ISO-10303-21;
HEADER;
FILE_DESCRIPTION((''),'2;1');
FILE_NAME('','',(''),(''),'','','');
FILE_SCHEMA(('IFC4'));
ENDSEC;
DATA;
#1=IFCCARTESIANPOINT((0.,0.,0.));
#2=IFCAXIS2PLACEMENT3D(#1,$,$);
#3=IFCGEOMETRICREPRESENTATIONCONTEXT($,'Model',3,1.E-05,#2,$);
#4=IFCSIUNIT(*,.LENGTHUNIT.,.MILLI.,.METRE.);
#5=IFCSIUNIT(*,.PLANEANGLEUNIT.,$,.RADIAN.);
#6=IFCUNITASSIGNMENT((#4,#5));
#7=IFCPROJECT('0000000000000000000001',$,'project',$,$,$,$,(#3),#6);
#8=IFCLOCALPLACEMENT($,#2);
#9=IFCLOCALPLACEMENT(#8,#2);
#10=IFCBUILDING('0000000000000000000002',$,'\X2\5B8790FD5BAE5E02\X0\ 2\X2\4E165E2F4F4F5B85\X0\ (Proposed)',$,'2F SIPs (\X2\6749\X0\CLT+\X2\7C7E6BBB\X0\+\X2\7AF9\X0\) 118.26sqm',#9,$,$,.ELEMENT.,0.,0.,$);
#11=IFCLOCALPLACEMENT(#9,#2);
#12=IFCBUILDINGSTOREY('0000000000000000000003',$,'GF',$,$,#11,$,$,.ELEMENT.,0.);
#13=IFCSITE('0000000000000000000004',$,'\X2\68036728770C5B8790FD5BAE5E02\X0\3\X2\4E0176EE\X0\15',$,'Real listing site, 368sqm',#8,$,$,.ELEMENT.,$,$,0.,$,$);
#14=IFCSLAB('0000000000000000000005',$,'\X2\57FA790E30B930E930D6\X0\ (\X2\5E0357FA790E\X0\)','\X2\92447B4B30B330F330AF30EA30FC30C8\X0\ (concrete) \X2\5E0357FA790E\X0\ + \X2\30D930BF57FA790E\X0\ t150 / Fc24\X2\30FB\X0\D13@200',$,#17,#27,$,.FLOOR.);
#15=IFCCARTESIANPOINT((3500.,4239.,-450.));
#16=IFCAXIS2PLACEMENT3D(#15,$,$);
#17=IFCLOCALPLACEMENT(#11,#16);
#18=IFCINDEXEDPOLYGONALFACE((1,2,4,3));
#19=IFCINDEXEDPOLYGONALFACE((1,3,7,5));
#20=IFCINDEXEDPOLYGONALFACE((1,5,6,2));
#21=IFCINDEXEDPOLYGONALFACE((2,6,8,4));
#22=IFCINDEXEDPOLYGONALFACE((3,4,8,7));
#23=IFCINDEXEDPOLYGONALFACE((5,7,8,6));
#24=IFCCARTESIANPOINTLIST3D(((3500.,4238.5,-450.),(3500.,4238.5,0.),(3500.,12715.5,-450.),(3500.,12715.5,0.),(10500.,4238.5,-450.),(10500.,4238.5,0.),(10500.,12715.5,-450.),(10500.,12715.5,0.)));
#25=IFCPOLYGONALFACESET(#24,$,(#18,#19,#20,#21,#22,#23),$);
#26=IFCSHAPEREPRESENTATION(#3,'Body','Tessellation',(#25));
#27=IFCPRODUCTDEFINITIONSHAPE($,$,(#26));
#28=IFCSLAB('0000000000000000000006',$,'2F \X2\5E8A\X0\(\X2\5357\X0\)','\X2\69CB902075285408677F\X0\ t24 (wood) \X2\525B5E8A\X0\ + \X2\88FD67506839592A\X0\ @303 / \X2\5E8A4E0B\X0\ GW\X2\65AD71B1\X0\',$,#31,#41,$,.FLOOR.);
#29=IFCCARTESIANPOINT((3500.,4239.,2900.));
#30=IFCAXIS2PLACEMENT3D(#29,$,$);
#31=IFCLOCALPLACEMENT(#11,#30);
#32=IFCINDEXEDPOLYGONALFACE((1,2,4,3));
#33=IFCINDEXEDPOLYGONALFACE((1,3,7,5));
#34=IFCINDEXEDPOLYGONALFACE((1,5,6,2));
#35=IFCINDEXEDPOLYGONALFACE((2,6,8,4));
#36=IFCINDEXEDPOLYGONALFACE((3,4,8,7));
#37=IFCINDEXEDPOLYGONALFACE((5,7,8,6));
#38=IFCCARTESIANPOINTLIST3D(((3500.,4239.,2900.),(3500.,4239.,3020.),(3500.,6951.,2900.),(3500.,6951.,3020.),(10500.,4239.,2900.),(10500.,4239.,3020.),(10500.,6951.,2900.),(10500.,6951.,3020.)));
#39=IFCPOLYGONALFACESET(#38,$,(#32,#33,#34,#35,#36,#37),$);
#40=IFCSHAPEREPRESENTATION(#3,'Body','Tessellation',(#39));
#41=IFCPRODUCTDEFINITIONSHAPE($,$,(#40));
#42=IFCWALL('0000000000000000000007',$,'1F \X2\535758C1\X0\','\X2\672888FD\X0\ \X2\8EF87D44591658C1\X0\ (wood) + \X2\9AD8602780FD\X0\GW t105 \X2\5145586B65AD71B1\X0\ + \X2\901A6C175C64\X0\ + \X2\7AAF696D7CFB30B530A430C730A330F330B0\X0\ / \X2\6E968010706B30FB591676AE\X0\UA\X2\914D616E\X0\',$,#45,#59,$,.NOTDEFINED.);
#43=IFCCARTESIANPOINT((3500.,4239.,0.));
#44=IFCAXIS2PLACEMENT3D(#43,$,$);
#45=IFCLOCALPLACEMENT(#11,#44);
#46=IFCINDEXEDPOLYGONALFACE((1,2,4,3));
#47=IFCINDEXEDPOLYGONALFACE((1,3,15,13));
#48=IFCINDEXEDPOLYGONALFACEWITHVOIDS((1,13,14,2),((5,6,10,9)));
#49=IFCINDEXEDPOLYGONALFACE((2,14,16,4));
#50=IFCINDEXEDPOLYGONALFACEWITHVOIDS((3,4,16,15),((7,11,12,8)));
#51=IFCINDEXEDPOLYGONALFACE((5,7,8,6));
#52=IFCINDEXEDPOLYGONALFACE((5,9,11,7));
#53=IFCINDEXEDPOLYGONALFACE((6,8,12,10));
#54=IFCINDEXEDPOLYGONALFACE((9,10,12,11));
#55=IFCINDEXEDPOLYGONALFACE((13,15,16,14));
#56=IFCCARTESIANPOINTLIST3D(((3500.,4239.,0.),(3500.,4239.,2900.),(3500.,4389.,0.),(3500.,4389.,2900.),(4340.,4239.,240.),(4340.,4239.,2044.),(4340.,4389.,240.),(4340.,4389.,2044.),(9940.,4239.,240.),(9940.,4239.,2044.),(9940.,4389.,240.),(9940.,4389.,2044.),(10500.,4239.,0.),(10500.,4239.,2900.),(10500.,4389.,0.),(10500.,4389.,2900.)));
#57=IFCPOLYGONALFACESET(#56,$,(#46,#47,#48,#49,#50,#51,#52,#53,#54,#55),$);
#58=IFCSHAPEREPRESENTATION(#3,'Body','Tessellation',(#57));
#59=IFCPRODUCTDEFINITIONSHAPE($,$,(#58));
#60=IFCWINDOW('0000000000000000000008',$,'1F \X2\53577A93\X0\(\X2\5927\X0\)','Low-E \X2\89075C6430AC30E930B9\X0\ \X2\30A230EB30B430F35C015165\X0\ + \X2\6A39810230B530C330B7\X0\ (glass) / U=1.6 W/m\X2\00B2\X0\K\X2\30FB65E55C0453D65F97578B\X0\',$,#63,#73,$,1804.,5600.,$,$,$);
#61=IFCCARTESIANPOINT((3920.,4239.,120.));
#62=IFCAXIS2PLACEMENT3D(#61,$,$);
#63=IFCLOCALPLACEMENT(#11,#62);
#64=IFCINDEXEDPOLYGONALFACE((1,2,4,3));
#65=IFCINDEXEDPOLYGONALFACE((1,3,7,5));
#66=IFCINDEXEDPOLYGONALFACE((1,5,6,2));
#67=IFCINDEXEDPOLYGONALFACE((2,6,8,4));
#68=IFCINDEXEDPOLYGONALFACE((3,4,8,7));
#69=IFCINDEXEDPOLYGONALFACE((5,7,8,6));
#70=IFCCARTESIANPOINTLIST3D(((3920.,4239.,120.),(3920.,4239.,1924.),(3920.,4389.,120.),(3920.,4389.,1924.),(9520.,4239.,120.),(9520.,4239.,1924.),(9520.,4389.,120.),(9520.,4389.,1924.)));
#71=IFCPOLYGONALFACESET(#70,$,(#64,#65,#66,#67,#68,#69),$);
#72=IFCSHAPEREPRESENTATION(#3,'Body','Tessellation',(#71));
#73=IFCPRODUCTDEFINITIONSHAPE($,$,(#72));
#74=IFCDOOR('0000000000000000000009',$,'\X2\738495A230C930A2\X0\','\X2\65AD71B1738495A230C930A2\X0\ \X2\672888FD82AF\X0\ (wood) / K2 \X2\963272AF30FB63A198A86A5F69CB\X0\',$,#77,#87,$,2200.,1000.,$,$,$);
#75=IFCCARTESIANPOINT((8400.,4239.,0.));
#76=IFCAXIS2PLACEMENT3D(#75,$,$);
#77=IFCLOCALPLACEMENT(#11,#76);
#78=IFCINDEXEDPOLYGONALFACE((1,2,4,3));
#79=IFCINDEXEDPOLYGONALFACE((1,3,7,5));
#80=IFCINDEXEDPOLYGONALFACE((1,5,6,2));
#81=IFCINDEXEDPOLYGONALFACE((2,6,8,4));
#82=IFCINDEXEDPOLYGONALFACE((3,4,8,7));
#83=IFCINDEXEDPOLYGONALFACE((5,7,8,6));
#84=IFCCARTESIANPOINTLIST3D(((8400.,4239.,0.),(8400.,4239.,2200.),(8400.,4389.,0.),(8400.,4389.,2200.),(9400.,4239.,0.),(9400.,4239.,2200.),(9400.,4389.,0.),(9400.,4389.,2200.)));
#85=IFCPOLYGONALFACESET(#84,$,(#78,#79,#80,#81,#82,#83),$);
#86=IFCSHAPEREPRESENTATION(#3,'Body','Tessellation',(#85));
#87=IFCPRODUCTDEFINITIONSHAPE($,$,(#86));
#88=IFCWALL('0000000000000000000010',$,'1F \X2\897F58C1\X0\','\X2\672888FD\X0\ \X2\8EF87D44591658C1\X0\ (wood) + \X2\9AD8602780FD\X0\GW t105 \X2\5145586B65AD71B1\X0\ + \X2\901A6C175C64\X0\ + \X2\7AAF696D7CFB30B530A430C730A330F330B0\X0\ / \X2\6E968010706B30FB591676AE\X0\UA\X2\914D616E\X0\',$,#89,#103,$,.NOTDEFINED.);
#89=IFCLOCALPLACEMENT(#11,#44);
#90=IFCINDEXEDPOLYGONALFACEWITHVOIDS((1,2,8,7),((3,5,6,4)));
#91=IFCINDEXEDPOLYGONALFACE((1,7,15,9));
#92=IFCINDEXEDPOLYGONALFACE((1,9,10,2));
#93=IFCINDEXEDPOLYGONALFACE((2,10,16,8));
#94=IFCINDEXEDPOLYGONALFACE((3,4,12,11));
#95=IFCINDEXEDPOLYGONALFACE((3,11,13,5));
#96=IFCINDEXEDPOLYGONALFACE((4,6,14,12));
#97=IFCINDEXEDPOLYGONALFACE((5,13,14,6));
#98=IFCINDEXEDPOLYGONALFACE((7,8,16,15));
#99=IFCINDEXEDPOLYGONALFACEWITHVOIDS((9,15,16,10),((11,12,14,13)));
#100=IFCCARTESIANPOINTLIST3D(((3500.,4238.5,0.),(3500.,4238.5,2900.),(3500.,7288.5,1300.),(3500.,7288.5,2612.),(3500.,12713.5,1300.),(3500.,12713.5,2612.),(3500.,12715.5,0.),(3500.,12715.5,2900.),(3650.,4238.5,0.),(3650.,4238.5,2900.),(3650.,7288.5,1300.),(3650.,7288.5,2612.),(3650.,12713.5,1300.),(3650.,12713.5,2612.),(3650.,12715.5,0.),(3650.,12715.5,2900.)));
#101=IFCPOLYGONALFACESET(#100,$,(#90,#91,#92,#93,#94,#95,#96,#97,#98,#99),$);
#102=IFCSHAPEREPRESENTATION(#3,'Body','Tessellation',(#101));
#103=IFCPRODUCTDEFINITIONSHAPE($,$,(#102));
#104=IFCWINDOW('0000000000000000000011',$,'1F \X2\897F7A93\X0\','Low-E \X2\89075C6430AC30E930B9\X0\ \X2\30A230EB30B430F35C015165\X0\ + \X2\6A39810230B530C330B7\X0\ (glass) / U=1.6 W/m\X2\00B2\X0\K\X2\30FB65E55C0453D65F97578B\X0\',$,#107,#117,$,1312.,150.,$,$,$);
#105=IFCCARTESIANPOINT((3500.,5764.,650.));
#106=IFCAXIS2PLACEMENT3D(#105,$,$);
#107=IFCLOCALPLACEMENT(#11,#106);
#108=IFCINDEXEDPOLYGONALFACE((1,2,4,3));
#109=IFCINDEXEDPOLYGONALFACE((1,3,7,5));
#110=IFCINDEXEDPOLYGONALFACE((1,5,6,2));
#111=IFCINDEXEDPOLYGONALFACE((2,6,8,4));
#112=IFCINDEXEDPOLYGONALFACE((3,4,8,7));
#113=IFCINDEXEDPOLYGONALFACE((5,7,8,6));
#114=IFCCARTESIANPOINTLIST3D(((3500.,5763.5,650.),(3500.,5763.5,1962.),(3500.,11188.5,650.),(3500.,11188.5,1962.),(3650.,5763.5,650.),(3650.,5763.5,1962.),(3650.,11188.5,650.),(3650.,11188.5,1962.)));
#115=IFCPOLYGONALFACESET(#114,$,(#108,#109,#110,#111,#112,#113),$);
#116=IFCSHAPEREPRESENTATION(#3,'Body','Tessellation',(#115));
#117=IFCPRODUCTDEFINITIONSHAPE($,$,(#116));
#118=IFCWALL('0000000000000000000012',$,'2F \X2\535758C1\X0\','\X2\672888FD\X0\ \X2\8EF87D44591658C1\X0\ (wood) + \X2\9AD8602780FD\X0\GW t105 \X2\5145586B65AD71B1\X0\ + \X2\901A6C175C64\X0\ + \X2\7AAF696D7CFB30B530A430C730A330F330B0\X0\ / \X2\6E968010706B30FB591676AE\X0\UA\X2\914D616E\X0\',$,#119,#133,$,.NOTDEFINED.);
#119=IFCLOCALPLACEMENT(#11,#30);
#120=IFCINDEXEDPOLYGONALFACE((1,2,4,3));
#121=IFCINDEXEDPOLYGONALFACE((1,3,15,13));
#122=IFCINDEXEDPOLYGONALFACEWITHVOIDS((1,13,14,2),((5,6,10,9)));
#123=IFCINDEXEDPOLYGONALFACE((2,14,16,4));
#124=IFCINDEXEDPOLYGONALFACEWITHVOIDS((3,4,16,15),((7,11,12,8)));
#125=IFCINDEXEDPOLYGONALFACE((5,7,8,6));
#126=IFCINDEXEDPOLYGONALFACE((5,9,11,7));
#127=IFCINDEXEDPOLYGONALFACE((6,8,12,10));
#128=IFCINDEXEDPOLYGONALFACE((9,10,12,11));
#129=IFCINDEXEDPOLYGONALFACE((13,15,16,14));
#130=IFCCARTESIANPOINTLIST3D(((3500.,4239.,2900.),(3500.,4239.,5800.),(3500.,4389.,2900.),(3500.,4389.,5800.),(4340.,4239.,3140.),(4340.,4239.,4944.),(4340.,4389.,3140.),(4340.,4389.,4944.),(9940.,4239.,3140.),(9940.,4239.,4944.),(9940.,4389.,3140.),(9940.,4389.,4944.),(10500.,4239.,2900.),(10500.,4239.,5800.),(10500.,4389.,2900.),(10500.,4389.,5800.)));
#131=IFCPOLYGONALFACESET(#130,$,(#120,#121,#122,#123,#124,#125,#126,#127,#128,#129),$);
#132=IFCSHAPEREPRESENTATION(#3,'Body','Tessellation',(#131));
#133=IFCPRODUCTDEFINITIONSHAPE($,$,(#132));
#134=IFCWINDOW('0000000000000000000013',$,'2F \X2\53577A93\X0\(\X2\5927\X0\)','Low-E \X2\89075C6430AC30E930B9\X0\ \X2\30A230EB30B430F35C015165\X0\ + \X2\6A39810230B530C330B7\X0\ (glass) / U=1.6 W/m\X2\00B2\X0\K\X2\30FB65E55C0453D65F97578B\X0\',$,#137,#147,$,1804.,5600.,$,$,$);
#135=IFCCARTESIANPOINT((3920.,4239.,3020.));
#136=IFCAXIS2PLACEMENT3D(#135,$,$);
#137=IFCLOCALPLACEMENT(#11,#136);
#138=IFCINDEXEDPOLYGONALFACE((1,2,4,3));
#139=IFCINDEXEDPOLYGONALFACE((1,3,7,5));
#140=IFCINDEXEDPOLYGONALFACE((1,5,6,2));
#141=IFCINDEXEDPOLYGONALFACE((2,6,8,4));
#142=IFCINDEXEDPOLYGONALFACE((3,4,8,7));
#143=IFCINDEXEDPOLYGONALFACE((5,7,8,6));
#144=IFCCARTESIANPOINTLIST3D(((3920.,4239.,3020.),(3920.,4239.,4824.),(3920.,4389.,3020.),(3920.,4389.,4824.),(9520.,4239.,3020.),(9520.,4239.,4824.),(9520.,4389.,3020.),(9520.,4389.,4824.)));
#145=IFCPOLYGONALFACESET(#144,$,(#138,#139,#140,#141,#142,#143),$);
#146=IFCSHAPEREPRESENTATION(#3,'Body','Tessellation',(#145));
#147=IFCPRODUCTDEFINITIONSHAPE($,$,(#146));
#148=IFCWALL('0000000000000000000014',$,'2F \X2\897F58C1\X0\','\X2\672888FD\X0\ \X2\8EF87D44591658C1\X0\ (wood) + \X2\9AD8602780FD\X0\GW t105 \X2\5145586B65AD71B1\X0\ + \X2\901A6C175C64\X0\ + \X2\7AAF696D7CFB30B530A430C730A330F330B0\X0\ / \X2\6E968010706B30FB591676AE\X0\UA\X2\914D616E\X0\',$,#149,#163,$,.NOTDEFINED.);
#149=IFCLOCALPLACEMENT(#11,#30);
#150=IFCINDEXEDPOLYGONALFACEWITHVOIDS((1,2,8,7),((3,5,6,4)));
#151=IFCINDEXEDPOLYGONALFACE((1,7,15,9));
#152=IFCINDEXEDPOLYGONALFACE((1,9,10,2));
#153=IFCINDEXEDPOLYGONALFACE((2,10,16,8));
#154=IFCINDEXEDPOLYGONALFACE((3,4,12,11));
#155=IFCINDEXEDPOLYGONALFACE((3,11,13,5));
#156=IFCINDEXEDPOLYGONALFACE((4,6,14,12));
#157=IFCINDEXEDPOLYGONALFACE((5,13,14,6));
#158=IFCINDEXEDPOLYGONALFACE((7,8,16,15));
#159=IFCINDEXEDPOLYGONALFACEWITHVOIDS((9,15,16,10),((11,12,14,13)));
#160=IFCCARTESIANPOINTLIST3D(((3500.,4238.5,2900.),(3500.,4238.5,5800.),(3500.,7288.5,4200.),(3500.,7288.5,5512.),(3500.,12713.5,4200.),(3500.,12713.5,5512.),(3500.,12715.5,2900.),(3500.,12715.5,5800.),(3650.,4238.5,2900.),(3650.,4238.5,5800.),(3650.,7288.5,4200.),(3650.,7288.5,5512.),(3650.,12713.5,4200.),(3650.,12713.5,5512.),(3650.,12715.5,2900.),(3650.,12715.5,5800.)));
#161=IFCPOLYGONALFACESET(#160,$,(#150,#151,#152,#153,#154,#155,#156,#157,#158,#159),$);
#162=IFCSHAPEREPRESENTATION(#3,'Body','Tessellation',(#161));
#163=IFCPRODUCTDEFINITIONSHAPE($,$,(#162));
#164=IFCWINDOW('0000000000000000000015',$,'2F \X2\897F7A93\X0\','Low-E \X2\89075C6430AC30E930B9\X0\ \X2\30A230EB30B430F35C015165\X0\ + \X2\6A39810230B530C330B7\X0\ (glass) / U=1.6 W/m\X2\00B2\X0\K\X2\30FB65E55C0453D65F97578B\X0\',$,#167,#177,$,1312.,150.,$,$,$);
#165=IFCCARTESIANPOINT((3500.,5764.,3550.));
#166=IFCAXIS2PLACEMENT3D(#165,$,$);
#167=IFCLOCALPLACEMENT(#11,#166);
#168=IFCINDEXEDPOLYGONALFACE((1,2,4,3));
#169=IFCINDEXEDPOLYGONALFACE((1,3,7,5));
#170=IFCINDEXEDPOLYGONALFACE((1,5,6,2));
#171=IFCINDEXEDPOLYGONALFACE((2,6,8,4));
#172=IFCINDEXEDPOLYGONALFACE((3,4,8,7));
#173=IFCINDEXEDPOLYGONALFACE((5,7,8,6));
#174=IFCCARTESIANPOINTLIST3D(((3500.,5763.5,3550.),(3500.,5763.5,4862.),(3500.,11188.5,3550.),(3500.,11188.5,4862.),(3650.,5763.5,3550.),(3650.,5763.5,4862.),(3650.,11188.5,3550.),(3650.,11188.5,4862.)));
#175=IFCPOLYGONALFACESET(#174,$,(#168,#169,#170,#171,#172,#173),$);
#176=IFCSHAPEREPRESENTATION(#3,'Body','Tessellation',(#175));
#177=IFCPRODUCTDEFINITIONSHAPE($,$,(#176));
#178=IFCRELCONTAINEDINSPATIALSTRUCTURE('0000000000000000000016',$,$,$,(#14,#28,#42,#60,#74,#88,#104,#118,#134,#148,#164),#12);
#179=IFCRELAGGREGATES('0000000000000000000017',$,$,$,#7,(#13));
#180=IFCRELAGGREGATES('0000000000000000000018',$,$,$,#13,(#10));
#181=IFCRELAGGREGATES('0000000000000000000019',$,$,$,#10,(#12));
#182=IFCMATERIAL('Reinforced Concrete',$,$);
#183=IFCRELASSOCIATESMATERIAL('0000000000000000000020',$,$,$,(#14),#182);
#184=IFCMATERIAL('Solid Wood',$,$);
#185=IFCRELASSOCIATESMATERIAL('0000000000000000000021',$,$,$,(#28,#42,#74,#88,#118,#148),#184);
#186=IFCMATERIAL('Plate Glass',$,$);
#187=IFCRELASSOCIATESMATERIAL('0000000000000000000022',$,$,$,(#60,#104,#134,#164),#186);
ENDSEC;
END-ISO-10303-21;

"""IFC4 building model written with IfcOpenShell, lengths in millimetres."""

from ifc_helpers import new_model, si_unit, frame, frame_2d, origin, place, context, project, spatial, rectangle, extrude, material, element, fill, save


model = new_model("IFC4")

# Units and contexts
model_context = context("Model", 3, precision=1e-05, world=origin())
ifc_project = project(units=[si_unit("LENGTHUNIT", "METRE", prefix="MILLI"), si_unit("PLANEANGLEUNIT", "RADIAN")], contexts=[model_context])

# Site, building, storey
site_placement = place(None, origin())
site = spatial("IfcSite", under=ifc_project, at=site_placement, Name="栃木県宇都宮市3丁目15", ObjectType="Real listing site, 368sqm", CompositionType="ELEMENT", RefElevation=0.0)
building_placement = place(site_placement, origin())
building = spatial("IfcBuilding", under=site, at=building_placement, Name="宇都宮市 2世帯住宅 (Proposed)", ObjectType="2F SIPs (杉CLT+籾殻+竹) 118.26sqm", CompositionType="ELEMENT", ElevationOfRefHeight=0.0, ElevationOfTerrain=0.0)
storey_placement = place(building_placement, origin())
storey = spatial("IfcBuildingStorey", under=building, at=storey_placement, Name="GF", CompositionType="ELEMENT", Elevation=0.0)

# Slabs
ifc_material_1 = material(Name="Reinforced Concrete")
slab_1_placement = place(storey_placement, frame((3500.0, 4239.0, -450.0)))
element("IfcSlab", 1, at=slab_1_placement, inside=storey, material=ifc_material_1, Name="基礎スラブ (布基礎)", Description="鉄筋コンクリート (concrete) 布基礎 + ベタ基礎 t150 / Fc24・D13@200", PredefinedType="FLOOR", context=model_context, shape_type="SweptSolid", body=[
    extrude(rectangle(XDim=7000.0, YDim=8477.0, at=frame_2d((3500.0, 4238.0))), frame((3500.0, 4239.0, -450.0)), (0.0, 0.0, 1.0), 450.0),
])
ifc_material_2 = material(Name="Solid Wood")
slab_2_placement = place(storey_placement, frame((3500.0, 4239.0, 2900.0)))
element("IfcSlab", 2, at=slab_2_placement, inside=storey, material=ifc_material_2, Name="2F 床(南)", Description="構造用合板 t24 (wood) 剛床 + 製材根太 @303 / 床下 GW断熱", PredefinedType="FLOOR", context=model_context, shape_type="SweptSolid", body=[
    extrude(rectangle(XDim=7000.0, YDim=2712.0, at=frame_2d((3500.0, 1356.0))), frame((3500.0, 4239.0, 2900.0)), (0.0, 0.0, 1.0), 120.0),
])

# Wall, openings, window, door
wall_1_placement = place(storey_placement, frame((3500.0, 4239.0, 0.0)))
wall_1 = element("IfcWall", 3, at=wall_1_placement, inside=storey, material=ifc_material_2, Name="1F 南壁", Description="木製 軸組外壁 (wood) + 高性能GW t105 充填断熱 + 通気層 + 窯業系サイディング / 準耐火・外皮UA配慮", PredefinedType="NOTDEFINED", context=model_context, shape_type="SweptSolid", body=[
    extrude(rectangle(XDim=7000.0, YDim=150.0, at=frame_2d((3500.0, 75.0))), frame((3500.0, 4239.0, 0.0)), (0.0, 0.0, 1.0), 2900.0),
])
opening_1_placement = place(storey_placement, frame((3920.0, 4239.0, 120.0)))
opening_1 = element("IfcOpeningElement", 4, at=opening_1_placement, cuts=wall_1, PredefinedType="NOTDEFINED", context=model_context, shape_type="SweptSolid", body=[
    extrude(rectangle(XDim=5600.0, YDim=150.0, at=frame_2d((2800.0, 75.0))), frame((3920.0, 4239.0, 120.0)), (0.0, 0.0, 1.0), 1804.0),
])
opening_2_placement = place(storey_placement, frame((8400.0, 4239.0, 0.0)))
opening_2 = element("IfcOpeningElement", 5, at=opening_2_placement, cuts=wall_1, PredefinedType="NOTDEFINED", context=model_context, shape_type="SweptSolid", body=[
    extrude(rectangle(XDim=1000.0, YDim=150.0, at=frame_2d((500.0, 75.0))), frame((8400.0, 4239.0, 0.0)), (0.0, 0.0, 1.0), 2200.0),
])
ifc_material_3 = material(Name="Plate Glass")
window_1_placement = place(storey_placement, frame((3920.0, 4239.0, 120.0)))
window_1 = element("IfcWindow", 6, at=window_1_placement, inside=storey, material=ifc_material_3, Name="1F 南窓(大)", Description="Low-E 複層ガラス アルゴン封入 + 樹脂サッシ (glass) / U=1.6 W/m²K・日射取得型", OverallHeight=1804.0, OverallWidth=5600.0, context=model_context, shape_type="SweptSolid", body=[
    extrude(rectangle(XDim=5600.0, YDim=150.0, at=frame_2d((2800.0, 75.0))), frame((3920.0, 4239.0, 120.0)), (0.0, 0.0, 1.0), 1804.0),
])
fill(opening_1, window_1)
door_placement = place(storey_placement, frame((8400.0, 4239.0, 0.0)))
door = element("IfcDoor", 7, at=door_placement, inside=storey, material=ifc_material_2, Name="玄関ドア", Description="断熱玄関ドア 木製芯 (wood) / K2 防犯・採風機構", OverallHeight=2200.0, OverallWidth=1000.0, context=model_context, shape_type="SweptSolid", body=[
    extrude(rectangle(XDim=1000.0, YDim=150.0, at=frame_2d((500.0, 75.0))), frame((8400.0, 4239.0, 0.0)), (0.0, 0.0, 1.0), 2200.0),
])
fill(opening_2, door)

# Walls, openings, windows
wall_2_placement = place(storey_placement, frame((3500.0, 4239.0, 0.0)))
wall_2 = element("IfcWall", 8, at=wall_2_placement, inside=storey, material=ifc_material_2, Name="1F 西壁", Description="木製 軸組外壁 (wood) + 高性能GW t105 充填断熱 + 通気層 + 窯業系サイディング / 準耐火・外皮UA配慮", PredefinedType="NOTDEFINED", context=model_context, shape_type="SweptSolid", body=[
    extrude(rectangle(XDim=150.0, YDim=8477.0, at=frame_2d((75.0, 4238.0))), frame((3500.0, 4239.0, 0.0)), (0.0, 0.0, 1.0), 2900.0),
])
opening_3_placement = place(storey_placement, frame((3500.0, 5764.0, 650.0)))
opening_3 = element("IfcOpeningElement", 9, at=opening_3_placement, cuts=wall_2, PredefinedType="NOTDEFINED", context=model_context, shape_type="SweptSolid", body=[
    extrude(rectangle(XDim=150.0, YDim=5425.0, at=frame_2d((75.0, 2712.0))), frame((3500.0, 5764.0, 650.0)), (0.0, 0.0, 1.0), 1312.0),
])
window_2_placement = place(storey_placement, frame((3500.0, 5764.0, 650.0)))
window_2 = element("IfcWindow", 10, at=window_2_placement, inside=storey, material=ifc_material_3, Name="1F 西窓", Description="Low-E 複層ガラス アルゴン封入 + 樹脂サッシ (glass) / U=1.6 W/m²K・日射取得型", OverallHeight=1312.0, OverallWidth=150.0, context=model_context, shape_type="SweptSolid", body=[
    extrude(rectangle(XDim=150.0, YDim=5425.0, at=frame_2d((75.0, 2712.0))), frame((3500.0, 5764.0, 650.0)), (0.0, 0.0, 1.0), 1312.0),
])
fill(opening_3, window_2)
wall_3_placement = place(storey_placement, frame((3500.0, 4239.0, 2900.0)))
wall_3 = element("IfcWall", 11, at=wall_3_placement, inside=storey, material=ifc_material_2, Name="2F 南壁", Description="木製 軸組外壁 (wood) + 高性能GW t105 充填断熱 + 通気層 + 窯業系サイディング / 準耐火・外皮UA配慮", PredefinedType="NOTDEFINED", context=model_context, shape_type="SweptSolid", body=[
    extrude(rectangle(XDim=7000.0, YDim=150.0, at=frame_2d((3500.0, 75.0))), frame((3500.0, 4239.0, 2900.0)), (0.0, 0.0, 1.0), 2900.0),
])
opening_4_placement = place(storey_placement, frame((3920.0, 4239.0, 3020.0)))
opening_4 = element("IfcOpeningElement", 12, at=opening_4_placement, cuts=wall_3, PredefinedType="NOTDEFINED", context=model_context, shape_type="SweptSolid", body=[
    extrude(rectangle(XDim=5600.0, YDim=150.0, at=frame_2d((2800.0, 75.0))), frame((3920.0, 4239.0, 3020.0)), (0.0, 0.0, 1.0), 1804.0),
])
window_3_placement = place(storey_placement, frame((3920.0, 4239.0, 3020.0)))
window_3 = element("IfcWindow", 13, at=window_3_placement, inside=storey, material=ifc_material_3, Name="2F 南窓(大)", Description="Low-E 複層ガラス アルゴン封入 + 樹脂サッシ (glass) / U=1.6 W/m²K・日射取得型", OverallHeight=1804.0, OverallWidth=5600.0, context=model_context, shape_type="SweptSolid", body=[
    extrude(rectangle(XDim=5600.0, YDim=150.0, at=frame_2d((2800.0, 75.0))), frame((3920.0, 4239.0, 3020.0)), (0.0, 0.0, 1.0), 1804.0),
])
fill(opening_4, window_3)
wall_4_placement = place(storey_placement, frame((3500.0, 4239.0, 2900.0)))
wall_4 = element("IfcWall", 14, at=wall_4_placement, inside=storey, material=ifc_material_2, Name="2F 西壁", Description="木製 軸組外壁 (wood) + 高性能GW t105 充填断熱 + 通気層 + 窯業系サイディング / 準耐火・外皮UA配慮", PredefinedType="NOTDEFINED", context=model_context, shape_type="SweptSolid", body=[
    extrude(rectangle(XDim=150.0, YDim=8477.0, at=frame_2d((75.0, 4238.0))), frame((3500.0, 4239.0, 2900.0)), (0.0, 0.0, 1.0), 2900.0),
])
opening_5_placement = place(storey_placement, frame((3500.0, 5764.0, 3550.0)))
opening_5 = element("IfcOpeningElement", 15, at=opening_5_placement, cuts=wall_4, PredefinedType="NOTDEFINED", context=model_context, shape_type="SweptSolid", body=[
    extrude(rectangle(XDim=150.0, YDim=5425.0, at=frame_2d((75.0, 2712.0))), frame((3500.0, 5764.0, 3550.0)), (0.0, 0.0, 1.0), 1312.0),
])
window_4_placement = place(storey_placement, frame((3500.0, 5764.0, 3550.0)))
window_4 = element("IfcWindow", 16, at=window_4_placement, inside=storey, material=ifc_material_3, Name="2F 西窓", Description="Low-E 複層ガラス アルゴン封入 + 樹脂サッシ (glass) / U=1.6 W/m²K・日射取得型", OverallHeight=1312.0, OverallWidth=150.0, context=model_context, shape_type="SweptSolid", body=[
    extrude(rectangle(XDim=150.0, YDim=5425.0, at=frame_2d((75.0, 2712.0))), frame((3500.0, 5764.0, 3550.0)), (0.0, 0.0, 1.0), 1312.0),
])
fill(opening_5, window_4)

save(model, "model.ifc")
